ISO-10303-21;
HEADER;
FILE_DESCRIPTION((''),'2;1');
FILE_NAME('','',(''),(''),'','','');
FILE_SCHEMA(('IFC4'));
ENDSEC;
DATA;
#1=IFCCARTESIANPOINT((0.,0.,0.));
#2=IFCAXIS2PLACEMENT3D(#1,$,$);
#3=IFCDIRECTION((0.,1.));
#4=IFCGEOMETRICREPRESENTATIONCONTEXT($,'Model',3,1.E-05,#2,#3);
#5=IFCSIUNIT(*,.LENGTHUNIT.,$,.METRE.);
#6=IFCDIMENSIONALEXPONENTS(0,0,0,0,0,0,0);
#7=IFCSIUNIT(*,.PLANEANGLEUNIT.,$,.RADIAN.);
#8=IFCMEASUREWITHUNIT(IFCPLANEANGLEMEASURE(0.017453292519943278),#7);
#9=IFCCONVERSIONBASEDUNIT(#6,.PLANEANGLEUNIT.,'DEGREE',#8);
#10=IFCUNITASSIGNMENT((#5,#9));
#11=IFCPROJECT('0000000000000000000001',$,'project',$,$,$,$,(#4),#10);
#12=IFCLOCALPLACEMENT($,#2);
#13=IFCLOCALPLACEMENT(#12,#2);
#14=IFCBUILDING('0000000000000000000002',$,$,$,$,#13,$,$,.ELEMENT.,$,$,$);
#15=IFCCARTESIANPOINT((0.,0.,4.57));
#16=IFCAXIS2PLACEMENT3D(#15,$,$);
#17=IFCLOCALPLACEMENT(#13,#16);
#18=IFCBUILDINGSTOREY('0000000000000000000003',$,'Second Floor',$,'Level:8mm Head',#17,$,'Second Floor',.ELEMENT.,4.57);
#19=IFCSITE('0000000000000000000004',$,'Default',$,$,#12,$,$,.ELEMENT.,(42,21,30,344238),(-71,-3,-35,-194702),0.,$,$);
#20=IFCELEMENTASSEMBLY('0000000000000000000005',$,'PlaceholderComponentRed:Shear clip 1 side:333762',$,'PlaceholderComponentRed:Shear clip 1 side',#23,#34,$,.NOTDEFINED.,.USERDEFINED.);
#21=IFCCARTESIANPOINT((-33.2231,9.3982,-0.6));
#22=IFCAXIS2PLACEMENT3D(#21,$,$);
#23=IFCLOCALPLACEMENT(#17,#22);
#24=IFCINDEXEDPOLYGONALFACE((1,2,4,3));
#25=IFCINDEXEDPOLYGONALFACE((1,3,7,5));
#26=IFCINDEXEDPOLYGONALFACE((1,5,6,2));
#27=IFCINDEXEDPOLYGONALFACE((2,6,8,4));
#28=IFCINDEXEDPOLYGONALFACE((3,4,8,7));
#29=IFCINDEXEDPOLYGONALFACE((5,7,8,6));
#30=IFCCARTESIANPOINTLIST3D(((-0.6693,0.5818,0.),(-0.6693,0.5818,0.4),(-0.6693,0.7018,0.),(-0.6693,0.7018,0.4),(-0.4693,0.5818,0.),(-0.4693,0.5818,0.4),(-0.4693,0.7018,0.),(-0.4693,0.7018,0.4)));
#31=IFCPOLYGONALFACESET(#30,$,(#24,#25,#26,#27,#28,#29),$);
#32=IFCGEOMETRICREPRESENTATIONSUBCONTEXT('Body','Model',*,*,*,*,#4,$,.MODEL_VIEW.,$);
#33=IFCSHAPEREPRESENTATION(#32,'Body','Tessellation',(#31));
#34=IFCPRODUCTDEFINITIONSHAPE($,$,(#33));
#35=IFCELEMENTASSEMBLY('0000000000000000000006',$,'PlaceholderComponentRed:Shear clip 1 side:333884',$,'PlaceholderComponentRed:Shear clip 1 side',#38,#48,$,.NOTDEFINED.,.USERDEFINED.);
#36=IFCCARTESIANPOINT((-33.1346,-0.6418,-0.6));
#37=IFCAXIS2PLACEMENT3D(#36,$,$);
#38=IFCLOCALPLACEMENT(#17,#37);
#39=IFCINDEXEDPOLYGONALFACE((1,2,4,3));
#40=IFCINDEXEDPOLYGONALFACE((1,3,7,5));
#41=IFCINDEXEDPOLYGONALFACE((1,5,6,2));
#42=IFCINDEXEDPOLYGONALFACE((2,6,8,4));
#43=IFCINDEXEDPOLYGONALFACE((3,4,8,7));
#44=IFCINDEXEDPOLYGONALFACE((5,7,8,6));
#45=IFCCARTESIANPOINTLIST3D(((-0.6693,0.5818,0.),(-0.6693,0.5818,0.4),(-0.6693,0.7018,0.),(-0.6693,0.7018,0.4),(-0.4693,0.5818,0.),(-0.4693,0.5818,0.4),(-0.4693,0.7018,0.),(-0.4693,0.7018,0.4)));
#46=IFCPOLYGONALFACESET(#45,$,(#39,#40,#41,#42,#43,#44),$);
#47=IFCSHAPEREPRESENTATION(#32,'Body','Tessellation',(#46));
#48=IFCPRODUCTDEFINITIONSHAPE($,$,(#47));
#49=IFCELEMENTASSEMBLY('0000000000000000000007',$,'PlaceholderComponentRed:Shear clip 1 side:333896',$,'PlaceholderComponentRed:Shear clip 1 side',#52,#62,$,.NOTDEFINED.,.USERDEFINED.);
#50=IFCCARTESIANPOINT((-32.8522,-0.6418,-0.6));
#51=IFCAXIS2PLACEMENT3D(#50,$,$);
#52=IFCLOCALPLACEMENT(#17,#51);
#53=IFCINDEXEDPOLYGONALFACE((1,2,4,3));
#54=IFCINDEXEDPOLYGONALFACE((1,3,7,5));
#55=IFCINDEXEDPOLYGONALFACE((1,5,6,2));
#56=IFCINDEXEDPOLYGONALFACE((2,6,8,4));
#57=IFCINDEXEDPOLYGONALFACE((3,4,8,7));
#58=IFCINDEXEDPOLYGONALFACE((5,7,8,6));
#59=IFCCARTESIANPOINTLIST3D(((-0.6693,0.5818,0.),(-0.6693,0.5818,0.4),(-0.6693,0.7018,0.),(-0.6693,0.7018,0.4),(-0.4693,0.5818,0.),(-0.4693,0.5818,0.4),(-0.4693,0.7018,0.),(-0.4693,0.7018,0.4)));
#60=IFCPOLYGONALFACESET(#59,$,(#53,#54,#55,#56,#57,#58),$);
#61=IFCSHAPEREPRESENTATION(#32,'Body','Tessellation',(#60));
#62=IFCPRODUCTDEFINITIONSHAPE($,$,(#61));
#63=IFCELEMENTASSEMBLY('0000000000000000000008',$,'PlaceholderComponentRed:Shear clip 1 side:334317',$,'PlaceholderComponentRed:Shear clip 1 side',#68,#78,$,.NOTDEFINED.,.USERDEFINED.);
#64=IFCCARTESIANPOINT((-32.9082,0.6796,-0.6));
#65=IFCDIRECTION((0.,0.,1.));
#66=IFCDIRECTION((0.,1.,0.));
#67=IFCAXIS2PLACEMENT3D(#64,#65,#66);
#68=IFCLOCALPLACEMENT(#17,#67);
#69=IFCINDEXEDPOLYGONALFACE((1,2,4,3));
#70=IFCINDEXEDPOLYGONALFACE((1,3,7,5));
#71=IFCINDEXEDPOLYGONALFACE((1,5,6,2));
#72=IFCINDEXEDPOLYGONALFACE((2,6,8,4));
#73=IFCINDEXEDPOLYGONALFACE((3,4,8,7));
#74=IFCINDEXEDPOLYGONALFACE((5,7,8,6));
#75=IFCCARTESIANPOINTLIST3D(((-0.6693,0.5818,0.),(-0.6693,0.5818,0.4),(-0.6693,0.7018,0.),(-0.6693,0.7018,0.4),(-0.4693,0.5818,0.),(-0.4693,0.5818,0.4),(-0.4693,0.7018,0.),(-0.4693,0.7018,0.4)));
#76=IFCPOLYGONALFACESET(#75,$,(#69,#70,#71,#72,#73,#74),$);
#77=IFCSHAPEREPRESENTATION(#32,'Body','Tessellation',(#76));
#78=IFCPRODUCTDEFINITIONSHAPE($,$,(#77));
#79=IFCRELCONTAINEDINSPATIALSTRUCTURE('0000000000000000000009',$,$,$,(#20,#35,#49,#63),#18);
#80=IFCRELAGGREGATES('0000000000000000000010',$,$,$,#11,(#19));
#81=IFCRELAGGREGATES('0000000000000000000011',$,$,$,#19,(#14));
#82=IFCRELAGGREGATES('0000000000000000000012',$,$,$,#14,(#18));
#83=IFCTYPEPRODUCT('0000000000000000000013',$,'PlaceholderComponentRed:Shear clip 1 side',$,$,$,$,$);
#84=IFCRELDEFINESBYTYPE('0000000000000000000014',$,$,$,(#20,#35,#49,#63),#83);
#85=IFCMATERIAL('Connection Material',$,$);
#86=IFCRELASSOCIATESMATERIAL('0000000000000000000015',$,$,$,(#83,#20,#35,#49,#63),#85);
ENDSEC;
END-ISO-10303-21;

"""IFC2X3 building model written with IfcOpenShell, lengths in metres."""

from ifc_helpers import new_model, entity, si_unit, converted_unit, direction, frame, frame_2d, origin, place, context, subcontext, project, spatial, rectangle, extrude, source, transform, mapped, material, type_object, type_shapes, element, save


model = new_model("IFC2X3")

# Units and contexts
model_context = context("Model", 3, precision=1e-05, world=origin(), true_north=direction((0.0, 1.0)))
body_context = subcontext(model_context, "Body", "Model", "MODEL_VIEW")
ifc_project = project(units=[si_unit("LENGTHUNIT", "METRE"), converted_unit("PLANEANGLEUNIT", "DEGREE", entity("IfcPlaneAngleMeasure", 0.017453292519943278), si_unit("PLANEANGLEUNIT", "RADIAN"), dimensions=[0, 0, 0, 0, 0, 0, 0])], contexts=[model_context])

# Site, building, storey
site_placement = place(None, origin())
site = spatial("IfcSite", under=ifc_project, at=site_placement, Name="Default", CompositionType="ELEMENT", RefLatitude=(42, 21, 30, 344238), RefLongitude=(-71, -3, -35, -194702), RefElevation=0.0)
building_placement = place(site_placement, origin())
building = spatial("IfcBuilding", under=site, at=building_placement, CompositionType="ELEMENT")
storey_placement = place(building_placement, frame((0.0, 0.0, 4.57)))
storey = spatial("IfcBuildingStorey", under=building, at=storey_placement, Name="Second Floor", ObjectType="Level:8mm Head", LongName="Second Floor", CompositionType="ELEMENT", Elevation=4.57)

# Element assemblies
ifc_material_1 = material(Name="Connection Material")
type_product = type_object("IfcTypeProduct", Name="PlaceholderComponentRed:Shear clip 1 side", material=ifc_material_1)
shared_shape = source(origin(), body_context, "Body", "SweptSolid", [
    extrude(rectangle(XDim=0.12, YDim=0.2, at=frame_2d((0.0, 0.0), x_axis=(1.0, 0.0))), frame((-0.5693, 0.6418, 0.0), z_axis=(0.0, 0.0, 1.0), x_axis=(0.0, 1.0, 0.0)), (0.0, 0.0, 1.0), 0.4),
])
type_shapes(type_product, [shared_shape])
for number, where, name in (
    (1, (-33.2231, 9.3982, -0.6), "PlaceholderComponentRed:Shear clip 1 side:333762"),
    (2, (-33.1346, -0.6418, -0.6), "PlaceholderComponentRed:Shear clip 1 side:333884"),
    (3, (-32.8522, -0.6418, -0.6), "PlaceholderComponentRed:Shear clip 1 side:333896"),
):
    element("IfcElementAssembly", number, at=place(storey_placement, frame(where)), inside=storey, type_object=type_product, material=ifc_material_1, Name=name, ObjectType="PlaceholderComponentRed:Shear clip 1 side", AssemblyPlace="NOTDEFINED", PredefinedType="USERDEFINED", context=body_context, shape_type="MappedRepresentation", body=[
        mapped(shared_shape, transform((0.0, 0.0, 0.0), scale=1.0)),
    ])
assembly_placement = place(storey_placement, frame((-32.9082, 0.6796, -0.6), z_axis=(0.0, 0.0, 1.0), x_axis=(0.0, 1.0, 0.0)))
element("IfcElementAssembly", 4, at=assembly_placement, inside=storey, type_object=type_product, material=ifc_material_1, Name="PlaceholderComponentRed:Shear clip 1 side:334317", ObjectType="PlaceholderComponentRed:Shear clip 1 side", AssemblyPlace="NOTDEFINED", PredefinedType="USERDEFINED", context=body_context, shape_type="MappedRepresentation", body=[
    mapped(shared_shape, transform((0.0, 0.0, 0.0), scale=1.0)),
])

save(model, "model.ifc")
